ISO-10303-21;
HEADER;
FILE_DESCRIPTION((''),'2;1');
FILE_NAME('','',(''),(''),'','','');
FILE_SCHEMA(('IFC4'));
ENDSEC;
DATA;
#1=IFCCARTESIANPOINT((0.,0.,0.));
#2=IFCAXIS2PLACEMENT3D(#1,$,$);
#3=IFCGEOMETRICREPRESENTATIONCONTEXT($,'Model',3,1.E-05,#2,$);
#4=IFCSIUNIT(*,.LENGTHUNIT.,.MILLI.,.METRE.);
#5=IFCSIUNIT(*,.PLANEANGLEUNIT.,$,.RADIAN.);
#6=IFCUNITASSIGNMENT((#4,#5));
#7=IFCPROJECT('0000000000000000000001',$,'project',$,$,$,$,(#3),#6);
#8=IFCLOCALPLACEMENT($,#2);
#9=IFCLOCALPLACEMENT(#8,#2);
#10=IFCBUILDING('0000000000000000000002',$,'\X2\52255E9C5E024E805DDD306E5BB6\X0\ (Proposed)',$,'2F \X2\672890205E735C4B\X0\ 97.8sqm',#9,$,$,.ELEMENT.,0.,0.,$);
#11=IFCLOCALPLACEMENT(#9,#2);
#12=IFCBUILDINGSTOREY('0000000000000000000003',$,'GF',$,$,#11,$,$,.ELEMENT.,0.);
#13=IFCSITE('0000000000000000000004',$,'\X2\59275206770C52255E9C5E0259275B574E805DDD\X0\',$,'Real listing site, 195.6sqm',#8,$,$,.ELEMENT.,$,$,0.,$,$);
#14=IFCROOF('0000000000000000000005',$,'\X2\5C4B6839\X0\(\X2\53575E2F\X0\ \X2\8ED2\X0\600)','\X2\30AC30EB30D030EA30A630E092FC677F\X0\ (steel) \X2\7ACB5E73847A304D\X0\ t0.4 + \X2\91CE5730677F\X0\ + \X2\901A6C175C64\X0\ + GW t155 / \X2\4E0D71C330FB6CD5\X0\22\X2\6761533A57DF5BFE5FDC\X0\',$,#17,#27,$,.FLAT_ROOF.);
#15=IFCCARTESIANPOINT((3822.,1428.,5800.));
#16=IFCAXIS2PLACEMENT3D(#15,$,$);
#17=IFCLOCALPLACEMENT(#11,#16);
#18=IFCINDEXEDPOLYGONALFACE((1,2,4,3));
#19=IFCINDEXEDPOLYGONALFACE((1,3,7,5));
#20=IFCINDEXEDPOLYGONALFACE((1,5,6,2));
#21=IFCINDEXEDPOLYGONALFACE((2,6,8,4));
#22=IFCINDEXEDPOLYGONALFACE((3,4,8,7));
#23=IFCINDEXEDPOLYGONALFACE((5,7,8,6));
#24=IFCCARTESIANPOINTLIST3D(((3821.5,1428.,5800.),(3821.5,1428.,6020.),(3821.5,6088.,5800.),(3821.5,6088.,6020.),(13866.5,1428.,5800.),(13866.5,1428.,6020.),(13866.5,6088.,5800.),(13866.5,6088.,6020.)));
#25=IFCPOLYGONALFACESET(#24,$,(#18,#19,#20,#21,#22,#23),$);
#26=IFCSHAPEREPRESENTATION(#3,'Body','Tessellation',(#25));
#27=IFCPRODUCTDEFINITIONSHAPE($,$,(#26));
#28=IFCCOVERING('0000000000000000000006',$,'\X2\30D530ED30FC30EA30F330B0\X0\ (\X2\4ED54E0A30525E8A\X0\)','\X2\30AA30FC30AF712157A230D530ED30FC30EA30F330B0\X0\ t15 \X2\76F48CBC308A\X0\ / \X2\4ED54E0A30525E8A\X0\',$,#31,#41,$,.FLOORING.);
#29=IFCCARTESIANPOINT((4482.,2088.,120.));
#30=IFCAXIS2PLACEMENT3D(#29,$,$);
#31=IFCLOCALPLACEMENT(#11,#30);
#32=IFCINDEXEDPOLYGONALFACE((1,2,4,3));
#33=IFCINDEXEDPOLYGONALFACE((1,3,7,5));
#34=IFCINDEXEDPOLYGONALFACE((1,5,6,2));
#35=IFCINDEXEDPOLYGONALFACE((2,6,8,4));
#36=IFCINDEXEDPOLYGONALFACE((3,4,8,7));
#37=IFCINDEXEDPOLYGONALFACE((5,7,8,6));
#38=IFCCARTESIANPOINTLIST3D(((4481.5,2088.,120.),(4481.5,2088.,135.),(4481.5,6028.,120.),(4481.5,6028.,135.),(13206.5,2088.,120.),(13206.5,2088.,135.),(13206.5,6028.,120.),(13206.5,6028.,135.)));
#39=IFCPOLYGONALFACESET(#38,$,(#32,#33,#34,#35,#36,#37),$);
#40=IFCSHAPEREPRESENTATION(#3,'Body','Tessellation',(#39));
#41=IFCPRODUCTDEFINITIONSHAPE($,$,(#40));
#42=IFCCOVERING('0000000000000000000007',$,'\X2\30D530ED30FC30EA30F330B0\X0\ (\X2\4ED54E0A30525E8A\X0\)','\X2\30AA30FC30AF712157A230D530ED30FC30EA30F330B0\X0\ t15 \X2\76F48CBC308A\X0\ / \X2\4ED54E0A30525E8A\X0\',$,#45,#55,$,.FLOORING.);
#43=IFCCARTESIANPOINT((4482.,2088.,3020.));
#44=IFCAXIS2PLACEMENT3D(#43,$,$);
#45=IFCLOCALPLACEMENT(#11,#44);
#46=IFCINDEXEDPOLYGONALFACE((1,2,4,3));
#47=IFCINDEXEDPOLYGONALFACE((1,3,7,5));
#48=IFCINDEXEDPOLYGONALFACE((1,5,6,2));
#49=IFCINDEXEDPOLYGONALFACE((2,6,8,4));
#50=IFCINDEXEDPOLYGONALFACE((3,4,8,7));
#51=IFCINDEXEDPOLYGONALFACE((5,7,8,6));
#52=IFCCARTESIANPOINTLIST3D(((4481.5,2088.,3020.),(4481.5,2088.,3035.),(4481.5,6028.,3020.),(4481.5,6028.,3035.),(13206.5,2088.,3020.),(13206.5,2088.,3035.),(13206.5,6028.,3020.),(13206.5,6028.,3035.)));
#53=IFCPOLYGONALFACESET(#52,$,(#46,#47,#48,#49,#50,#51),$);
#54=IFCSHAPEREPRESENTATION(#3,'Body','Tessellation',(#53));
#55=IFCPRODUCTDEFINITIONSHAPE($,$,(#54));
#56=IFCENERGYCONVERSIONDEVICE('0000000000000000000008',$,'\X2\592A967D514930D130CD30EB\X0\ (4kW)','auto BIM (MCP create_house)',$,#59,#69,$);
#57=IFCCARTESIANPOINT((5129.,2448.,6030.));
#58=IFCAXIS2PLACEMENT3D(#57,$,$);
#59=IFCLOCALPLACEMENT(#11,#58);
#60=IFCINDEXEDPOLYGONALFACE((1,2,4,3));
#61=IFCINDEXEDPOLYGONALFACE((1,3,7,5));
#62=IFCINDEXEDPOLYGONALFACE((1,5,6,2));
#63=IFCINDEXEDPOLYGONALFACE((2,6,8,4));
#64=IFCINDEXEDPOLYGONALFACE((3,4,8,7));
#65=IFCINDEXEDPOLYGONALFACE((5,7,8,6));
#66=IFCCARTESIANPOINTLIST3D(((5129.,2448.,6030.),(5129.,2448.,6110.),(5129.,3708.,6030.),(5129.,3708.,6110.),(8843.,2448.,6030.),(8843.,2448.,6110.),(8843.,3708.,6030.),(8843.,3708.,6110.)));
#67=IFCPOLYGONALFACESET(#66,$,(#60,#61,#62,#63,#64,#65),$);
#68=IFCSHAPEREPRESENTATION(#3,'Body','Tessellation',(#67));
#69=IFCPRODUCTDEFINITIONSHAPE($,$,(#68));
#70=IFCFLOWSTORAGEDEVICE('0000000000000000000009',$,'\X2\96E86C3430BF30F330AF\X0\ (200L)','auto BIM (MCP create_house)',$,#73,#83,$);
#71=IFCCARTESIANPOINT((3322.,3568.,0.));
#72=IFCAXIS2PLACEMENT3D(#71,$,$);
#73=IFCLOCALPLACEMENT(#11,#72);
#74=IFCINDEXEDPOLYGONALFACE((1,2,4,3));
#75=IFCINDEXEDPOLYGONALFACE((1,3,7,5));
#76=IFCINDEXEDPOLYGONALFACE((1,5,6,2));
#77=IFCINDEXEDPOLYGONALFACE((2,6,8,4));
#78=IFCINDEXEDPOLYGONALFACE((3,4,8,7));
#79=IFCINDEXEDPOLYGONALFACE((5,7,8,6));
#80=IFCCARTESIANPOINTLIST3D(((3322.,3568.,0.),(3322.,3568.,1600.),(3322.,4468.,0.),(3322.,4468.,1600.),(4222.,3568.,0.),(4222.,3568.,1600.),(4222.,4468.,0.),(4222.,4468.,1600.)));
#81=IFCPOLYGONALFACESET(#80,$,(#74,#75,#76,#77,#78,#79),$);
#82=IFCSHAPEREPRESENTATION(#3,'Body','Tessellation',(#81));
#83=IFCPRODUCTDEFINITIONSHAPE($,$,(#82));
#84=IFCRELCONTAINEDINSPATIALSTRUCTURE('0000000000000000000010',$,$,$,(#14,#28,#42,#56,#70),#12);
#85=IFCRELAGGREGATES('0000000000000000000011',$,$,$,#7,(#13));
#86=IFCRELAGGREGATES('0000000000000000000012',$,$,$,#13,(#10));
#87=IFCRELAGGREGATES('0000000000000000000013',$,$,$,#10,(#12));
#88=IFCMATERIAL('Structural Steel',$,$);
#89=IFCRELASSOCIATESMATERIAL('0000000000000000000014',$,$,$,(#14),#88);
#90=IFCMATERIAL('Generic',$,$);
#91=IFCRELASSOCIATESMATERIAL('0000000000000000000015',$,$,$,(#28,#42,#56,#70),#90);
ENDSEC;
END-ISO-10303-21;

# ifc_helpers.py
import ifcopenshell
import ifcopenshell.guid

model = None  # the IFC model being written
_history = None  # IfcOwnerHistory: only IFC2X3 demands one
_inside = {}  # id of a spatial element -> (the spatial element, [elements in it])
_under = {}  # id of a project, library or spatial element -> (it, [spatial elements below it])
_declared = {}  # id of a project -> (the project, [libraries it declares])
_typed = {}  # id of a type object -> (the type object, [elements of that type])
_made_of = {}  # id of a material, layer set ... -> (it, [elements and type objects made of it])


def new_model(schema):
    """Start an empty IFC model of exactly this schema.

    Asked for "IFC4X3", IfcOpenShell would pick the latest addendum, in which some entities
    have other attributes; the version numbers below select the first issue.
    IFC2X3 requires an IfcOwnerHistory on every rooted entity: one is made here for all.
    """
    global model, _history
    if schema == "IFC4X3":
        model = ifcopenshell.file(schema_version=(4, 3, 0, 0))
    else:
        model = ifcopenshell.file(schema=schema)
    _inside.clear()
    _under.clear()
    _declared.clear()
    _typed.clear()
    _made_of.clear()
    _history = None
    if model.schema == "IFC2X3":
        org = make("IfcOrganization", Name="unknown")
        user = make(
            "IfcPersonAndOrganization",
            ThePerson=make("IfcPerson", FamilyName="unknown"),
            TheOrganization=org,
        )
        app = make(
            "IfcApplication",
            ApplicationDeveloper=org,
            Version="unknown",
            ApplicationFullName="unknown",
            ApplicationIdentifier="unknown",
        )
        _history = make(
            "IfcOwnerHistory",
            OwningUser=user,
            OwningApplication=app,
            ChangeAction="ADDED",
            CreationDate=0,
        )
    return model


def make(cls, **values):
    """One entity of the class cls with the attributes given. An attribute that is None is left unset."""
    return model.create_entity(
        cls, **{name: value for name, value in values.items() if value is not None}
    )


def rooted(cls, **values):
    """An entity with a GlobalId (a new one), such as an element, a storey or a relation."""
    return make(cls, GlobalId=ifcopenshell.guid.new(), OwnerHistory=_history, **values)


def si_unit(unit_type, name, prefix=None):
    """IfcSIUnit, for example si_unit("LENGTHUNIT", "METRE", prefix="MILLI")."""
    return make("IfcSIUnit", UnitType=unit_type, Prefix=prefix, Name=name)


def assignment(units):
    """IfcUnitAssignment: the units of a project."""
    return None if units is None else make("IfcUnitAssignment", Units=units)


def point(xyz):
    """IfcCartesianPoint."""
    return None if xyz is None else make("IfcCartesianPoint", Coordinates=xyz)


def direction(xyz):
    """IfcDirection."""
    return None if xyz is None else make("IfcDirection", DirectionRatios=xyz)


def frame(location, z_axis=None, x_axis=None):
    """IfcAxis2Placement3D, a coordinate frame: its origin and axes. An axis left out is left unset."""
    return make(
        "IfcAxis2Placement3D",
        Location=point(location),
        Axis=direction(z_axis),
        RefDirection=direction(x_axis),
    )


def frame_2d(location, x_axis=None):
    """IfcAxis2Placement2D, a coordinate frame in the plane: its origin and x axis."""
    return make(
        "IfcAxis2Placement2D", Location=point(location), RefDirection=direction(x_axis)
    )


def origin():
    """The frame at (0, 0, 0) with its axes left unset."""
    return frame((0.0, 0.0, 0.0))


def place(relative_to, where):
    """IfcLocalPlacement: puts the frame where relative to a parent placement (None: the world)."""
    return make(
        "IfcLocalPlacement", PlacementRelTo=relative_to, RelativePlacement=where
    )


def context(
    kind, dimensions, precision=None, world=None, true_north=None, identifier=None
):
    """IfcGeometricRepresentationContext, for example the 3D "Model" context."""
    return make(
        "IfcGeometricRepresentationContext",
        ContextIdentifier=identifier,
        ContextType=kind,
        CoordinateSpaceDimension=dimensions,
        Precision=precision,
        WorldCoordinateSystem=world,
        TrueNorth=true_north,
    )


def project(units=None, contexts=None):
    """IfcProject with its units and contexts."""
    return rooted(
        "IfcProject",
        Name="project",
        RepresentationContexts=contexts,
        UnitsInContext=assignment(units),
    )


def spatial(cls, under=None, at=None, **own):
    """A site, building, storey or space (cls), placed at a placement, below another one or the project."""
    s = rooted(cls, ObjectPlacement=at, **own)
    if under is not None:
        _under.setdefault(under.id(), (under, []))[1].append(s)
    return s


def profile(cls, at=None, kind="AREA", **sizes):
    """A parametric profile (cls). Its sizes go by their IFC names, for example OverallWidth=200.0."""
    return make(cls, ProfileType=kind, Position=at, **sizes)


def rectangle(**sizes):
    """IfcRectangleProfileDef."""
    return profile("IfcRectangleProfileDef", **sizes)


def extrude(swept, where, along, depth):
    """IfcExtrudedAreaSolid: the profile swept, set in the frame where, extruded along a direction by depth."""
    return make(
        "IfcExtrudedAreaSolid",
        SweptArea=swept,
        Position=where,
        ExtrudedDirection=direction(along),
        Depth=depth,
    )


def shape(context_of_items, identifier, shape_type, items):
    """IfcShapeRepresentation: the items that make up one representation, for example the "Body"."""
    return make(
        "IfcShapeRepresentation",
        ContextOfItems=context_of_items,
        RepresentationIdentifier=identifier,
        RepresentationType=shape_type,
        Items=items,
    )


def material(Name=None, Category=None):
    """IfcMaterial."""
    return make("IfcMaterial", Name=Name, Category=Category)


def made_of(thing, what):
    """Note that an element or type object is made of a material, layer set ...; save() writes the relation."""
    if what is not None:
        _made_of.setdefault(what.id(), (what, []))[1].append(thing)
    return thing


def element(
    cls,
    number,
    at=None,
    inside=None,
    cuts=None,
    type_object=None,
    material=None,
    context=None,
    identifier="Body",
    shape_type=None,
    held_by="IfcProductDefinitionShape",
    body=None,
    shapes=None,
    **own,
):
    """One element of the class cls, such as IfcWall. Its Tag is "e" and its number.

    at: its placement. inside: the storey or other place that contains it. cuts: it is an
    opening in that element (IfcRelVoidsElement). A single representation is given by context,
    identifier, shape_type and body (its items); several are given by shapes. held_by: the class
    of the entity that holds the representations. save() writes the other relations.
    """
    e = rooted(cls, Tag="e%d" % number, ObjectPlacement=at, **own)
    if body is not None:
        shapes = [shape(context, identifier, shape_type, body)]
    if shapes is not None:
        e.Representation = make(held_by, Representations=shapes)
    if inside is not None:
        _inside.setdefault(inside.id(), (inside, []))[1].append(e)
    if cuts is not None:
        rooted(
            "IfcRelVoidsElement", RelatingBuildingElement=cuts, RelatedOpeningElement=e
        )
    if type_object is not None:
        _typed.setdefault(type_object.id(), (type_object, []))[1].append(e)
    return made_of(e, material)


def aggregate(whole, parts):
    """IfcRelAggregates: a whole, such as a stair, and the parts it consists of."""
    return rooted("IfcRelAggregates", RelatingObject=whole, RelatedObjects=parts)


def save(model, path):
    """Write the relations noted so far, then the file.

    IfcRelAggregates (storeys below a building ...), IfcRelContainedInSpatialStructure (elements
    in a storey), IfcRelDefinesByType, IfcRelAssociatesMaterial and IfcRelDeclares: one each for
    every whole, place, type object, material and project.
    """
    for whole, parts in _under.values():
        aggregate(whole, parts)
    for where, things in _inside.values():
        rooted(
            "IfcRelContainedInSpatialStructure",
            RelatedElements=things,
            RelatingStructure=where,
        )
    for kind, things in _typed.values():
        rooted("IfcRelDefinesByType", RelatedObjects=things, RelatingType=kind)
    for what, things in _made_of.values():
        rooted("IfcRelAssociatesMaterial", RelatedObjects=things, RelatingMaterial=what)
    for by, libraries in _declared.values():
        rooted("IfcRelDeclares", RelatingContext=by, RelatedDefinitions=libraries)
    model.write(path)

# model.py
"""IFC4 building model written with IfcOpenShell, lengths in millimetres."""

from ifc_helpers import new_model, si_unit, frame, frame_2d, origin, place, context, project, spatial, rectangle, extrude, material, element, save


model = new_model("IFC4")

# Units and contexts
model_context = context("Model", 3, precision=1e-05, world=origin())
ifc_project = project(units=[si_unit("LENGTHUNIT", "METRE", prefix="MILLI"), si_unit("PLANEANGLEUNIT", "RADIAN")], contexts=[model_context])

# Site, building, storey
site_placement = place(None, origin())
site = spatial("IfcSite", under=ifc_project, at=site_placement, Name="大分県別府市大字亀川", ObjectType="Real listing site, 195.6sqm", CompositionType="ELEMENT", RefElevation=0.0)
building_placement = place(site_placement, origin())
building = spatial("IfcBuilding", under=site, at=building_placement, Name="別府市亀川の家 (Proposed)", ObjectType="2F 木造平屋 97.8sqm", CompositionType="ELEMENT", ElevationOfRefHeight=0.0, ElevationOfTerrain=0.0)
storey_placement = place(building_placement, origin())
storey = spatial("IfcBuildingStorey", under=building, at=storey_placement, Name="GF", CompositionType="ELEMENT", Elevation=0.0)

# Roof
ifc_material_1 = material(Name="Structural Steel")
for number, where, name in (
    (1, (3822.0, 1428.0, 5800.0), "屋根(南帯 軒600)"),
):
    element("IfcRoof", number, at=place(storey_placement, frame(where)), inside=storey, material=ifc_material_1, Name=name, Description="ガルバリウム鋼板 (steel) 立平葺き t0.4 + 野地板 + 通気層 + GW t155 / 不燃・法22条区域対応", PredefinedType="FLAT_ROOF", context=model_context, shape_type="SweptSolid", body=[
        extrude(rectangle(XDim=10045.0, YDim=4660.0, at=frame_2d((5022.0, 2330.0))), frame((3822.0, 1428.0, 5800.0)), (0.0, 0.0, 1.0), 220.0),
    ])

# Coverings
ifc_material_2 = material(Name="Generic")
covering_1_placement = place(storey_placement, frame((4482.0, 2088.0, 120.0)))
element("IfcCovering", 2, at=covering_1_placement, inside=storey, material=ifc_material_2, Name="フローリング (仕上げ床)", Description="オーク無垢フローリング t15 直貼り / 仕上げ床", PredefinedType="FLOORING", context=model_context, shape_type="SweptSolid", body=[
    extrude(rectangle(XDim=8725.0, YDim=3940.0, at=frame_2d((4362.0, 1970.0))), frame((4482.0, 2088.0, 120.0)), (0.0, 0.0, 1.0), 15.0),
])
covering_2_placement = place(storey_placement, frame((4482.0, 2088.0, 3020.0)))
element("IfcCovering", 3, at=covering_2_placement, inside=storey, material=ifc_material_2, Name="フローリング (仕上げ床)", Description="オーク無垢フローリング t15 直貼り / 仕上げ床", PredefinedType="FLOORING", context=model_context, shape_type="SweptSolid", body=[
    extrude(rectangle(XDim=8725.0, YDim=3940.0, at=frame_2d((4362.0, 1970.0))), frame((4482.0, 2088.0, 3020.0)), (0.0, 0.0, 1.0), 15.0),
])

# Energy conversion device
energy_conversion_device_placement = place(storey_placement, frame((5129.0, 2448.0, 6030.0)))
element("IfcEnergyConversionDevice", 4, at=energy_conversion_device_placement, inside=storey, material=ifc_material_2, Name="太陽光パネル (4kW)", Description="auto BIM (MCP create_house)", context=model_context, shape_type="SweptSolid", body=[
    extrude(rectangle(XDim=3714.0, YDim=1260.0, at=frame_2d((1857.0, 630.0))), frame((5129.0, 2448.0, 6030.0)), (0.0, 0.0, 1.0), 80.0),
])

# Flow storage device
flow_storage_device_placement = place(storey_placement, frame((3322.0, 3568.0, 0.0)))
element("IfcFlowStorageDevice", 5, at=flow_storage_device_placement, inside=storey, material=ifc_material_2, Name="雨水タンク (200L)", Description="auto BIM (MCP create_house)", context=model_context, shape_type="SweptSolid", body=[
    extrude(rectangle(XDim=900.0, YDim=900.0, at=frame_2d((450.0, 450.0))), frame((3322.0, 3568.0, 0.0)), (0.0, 0.0, 1.0), 1600.0),
])

save(model, "model.ifc")
